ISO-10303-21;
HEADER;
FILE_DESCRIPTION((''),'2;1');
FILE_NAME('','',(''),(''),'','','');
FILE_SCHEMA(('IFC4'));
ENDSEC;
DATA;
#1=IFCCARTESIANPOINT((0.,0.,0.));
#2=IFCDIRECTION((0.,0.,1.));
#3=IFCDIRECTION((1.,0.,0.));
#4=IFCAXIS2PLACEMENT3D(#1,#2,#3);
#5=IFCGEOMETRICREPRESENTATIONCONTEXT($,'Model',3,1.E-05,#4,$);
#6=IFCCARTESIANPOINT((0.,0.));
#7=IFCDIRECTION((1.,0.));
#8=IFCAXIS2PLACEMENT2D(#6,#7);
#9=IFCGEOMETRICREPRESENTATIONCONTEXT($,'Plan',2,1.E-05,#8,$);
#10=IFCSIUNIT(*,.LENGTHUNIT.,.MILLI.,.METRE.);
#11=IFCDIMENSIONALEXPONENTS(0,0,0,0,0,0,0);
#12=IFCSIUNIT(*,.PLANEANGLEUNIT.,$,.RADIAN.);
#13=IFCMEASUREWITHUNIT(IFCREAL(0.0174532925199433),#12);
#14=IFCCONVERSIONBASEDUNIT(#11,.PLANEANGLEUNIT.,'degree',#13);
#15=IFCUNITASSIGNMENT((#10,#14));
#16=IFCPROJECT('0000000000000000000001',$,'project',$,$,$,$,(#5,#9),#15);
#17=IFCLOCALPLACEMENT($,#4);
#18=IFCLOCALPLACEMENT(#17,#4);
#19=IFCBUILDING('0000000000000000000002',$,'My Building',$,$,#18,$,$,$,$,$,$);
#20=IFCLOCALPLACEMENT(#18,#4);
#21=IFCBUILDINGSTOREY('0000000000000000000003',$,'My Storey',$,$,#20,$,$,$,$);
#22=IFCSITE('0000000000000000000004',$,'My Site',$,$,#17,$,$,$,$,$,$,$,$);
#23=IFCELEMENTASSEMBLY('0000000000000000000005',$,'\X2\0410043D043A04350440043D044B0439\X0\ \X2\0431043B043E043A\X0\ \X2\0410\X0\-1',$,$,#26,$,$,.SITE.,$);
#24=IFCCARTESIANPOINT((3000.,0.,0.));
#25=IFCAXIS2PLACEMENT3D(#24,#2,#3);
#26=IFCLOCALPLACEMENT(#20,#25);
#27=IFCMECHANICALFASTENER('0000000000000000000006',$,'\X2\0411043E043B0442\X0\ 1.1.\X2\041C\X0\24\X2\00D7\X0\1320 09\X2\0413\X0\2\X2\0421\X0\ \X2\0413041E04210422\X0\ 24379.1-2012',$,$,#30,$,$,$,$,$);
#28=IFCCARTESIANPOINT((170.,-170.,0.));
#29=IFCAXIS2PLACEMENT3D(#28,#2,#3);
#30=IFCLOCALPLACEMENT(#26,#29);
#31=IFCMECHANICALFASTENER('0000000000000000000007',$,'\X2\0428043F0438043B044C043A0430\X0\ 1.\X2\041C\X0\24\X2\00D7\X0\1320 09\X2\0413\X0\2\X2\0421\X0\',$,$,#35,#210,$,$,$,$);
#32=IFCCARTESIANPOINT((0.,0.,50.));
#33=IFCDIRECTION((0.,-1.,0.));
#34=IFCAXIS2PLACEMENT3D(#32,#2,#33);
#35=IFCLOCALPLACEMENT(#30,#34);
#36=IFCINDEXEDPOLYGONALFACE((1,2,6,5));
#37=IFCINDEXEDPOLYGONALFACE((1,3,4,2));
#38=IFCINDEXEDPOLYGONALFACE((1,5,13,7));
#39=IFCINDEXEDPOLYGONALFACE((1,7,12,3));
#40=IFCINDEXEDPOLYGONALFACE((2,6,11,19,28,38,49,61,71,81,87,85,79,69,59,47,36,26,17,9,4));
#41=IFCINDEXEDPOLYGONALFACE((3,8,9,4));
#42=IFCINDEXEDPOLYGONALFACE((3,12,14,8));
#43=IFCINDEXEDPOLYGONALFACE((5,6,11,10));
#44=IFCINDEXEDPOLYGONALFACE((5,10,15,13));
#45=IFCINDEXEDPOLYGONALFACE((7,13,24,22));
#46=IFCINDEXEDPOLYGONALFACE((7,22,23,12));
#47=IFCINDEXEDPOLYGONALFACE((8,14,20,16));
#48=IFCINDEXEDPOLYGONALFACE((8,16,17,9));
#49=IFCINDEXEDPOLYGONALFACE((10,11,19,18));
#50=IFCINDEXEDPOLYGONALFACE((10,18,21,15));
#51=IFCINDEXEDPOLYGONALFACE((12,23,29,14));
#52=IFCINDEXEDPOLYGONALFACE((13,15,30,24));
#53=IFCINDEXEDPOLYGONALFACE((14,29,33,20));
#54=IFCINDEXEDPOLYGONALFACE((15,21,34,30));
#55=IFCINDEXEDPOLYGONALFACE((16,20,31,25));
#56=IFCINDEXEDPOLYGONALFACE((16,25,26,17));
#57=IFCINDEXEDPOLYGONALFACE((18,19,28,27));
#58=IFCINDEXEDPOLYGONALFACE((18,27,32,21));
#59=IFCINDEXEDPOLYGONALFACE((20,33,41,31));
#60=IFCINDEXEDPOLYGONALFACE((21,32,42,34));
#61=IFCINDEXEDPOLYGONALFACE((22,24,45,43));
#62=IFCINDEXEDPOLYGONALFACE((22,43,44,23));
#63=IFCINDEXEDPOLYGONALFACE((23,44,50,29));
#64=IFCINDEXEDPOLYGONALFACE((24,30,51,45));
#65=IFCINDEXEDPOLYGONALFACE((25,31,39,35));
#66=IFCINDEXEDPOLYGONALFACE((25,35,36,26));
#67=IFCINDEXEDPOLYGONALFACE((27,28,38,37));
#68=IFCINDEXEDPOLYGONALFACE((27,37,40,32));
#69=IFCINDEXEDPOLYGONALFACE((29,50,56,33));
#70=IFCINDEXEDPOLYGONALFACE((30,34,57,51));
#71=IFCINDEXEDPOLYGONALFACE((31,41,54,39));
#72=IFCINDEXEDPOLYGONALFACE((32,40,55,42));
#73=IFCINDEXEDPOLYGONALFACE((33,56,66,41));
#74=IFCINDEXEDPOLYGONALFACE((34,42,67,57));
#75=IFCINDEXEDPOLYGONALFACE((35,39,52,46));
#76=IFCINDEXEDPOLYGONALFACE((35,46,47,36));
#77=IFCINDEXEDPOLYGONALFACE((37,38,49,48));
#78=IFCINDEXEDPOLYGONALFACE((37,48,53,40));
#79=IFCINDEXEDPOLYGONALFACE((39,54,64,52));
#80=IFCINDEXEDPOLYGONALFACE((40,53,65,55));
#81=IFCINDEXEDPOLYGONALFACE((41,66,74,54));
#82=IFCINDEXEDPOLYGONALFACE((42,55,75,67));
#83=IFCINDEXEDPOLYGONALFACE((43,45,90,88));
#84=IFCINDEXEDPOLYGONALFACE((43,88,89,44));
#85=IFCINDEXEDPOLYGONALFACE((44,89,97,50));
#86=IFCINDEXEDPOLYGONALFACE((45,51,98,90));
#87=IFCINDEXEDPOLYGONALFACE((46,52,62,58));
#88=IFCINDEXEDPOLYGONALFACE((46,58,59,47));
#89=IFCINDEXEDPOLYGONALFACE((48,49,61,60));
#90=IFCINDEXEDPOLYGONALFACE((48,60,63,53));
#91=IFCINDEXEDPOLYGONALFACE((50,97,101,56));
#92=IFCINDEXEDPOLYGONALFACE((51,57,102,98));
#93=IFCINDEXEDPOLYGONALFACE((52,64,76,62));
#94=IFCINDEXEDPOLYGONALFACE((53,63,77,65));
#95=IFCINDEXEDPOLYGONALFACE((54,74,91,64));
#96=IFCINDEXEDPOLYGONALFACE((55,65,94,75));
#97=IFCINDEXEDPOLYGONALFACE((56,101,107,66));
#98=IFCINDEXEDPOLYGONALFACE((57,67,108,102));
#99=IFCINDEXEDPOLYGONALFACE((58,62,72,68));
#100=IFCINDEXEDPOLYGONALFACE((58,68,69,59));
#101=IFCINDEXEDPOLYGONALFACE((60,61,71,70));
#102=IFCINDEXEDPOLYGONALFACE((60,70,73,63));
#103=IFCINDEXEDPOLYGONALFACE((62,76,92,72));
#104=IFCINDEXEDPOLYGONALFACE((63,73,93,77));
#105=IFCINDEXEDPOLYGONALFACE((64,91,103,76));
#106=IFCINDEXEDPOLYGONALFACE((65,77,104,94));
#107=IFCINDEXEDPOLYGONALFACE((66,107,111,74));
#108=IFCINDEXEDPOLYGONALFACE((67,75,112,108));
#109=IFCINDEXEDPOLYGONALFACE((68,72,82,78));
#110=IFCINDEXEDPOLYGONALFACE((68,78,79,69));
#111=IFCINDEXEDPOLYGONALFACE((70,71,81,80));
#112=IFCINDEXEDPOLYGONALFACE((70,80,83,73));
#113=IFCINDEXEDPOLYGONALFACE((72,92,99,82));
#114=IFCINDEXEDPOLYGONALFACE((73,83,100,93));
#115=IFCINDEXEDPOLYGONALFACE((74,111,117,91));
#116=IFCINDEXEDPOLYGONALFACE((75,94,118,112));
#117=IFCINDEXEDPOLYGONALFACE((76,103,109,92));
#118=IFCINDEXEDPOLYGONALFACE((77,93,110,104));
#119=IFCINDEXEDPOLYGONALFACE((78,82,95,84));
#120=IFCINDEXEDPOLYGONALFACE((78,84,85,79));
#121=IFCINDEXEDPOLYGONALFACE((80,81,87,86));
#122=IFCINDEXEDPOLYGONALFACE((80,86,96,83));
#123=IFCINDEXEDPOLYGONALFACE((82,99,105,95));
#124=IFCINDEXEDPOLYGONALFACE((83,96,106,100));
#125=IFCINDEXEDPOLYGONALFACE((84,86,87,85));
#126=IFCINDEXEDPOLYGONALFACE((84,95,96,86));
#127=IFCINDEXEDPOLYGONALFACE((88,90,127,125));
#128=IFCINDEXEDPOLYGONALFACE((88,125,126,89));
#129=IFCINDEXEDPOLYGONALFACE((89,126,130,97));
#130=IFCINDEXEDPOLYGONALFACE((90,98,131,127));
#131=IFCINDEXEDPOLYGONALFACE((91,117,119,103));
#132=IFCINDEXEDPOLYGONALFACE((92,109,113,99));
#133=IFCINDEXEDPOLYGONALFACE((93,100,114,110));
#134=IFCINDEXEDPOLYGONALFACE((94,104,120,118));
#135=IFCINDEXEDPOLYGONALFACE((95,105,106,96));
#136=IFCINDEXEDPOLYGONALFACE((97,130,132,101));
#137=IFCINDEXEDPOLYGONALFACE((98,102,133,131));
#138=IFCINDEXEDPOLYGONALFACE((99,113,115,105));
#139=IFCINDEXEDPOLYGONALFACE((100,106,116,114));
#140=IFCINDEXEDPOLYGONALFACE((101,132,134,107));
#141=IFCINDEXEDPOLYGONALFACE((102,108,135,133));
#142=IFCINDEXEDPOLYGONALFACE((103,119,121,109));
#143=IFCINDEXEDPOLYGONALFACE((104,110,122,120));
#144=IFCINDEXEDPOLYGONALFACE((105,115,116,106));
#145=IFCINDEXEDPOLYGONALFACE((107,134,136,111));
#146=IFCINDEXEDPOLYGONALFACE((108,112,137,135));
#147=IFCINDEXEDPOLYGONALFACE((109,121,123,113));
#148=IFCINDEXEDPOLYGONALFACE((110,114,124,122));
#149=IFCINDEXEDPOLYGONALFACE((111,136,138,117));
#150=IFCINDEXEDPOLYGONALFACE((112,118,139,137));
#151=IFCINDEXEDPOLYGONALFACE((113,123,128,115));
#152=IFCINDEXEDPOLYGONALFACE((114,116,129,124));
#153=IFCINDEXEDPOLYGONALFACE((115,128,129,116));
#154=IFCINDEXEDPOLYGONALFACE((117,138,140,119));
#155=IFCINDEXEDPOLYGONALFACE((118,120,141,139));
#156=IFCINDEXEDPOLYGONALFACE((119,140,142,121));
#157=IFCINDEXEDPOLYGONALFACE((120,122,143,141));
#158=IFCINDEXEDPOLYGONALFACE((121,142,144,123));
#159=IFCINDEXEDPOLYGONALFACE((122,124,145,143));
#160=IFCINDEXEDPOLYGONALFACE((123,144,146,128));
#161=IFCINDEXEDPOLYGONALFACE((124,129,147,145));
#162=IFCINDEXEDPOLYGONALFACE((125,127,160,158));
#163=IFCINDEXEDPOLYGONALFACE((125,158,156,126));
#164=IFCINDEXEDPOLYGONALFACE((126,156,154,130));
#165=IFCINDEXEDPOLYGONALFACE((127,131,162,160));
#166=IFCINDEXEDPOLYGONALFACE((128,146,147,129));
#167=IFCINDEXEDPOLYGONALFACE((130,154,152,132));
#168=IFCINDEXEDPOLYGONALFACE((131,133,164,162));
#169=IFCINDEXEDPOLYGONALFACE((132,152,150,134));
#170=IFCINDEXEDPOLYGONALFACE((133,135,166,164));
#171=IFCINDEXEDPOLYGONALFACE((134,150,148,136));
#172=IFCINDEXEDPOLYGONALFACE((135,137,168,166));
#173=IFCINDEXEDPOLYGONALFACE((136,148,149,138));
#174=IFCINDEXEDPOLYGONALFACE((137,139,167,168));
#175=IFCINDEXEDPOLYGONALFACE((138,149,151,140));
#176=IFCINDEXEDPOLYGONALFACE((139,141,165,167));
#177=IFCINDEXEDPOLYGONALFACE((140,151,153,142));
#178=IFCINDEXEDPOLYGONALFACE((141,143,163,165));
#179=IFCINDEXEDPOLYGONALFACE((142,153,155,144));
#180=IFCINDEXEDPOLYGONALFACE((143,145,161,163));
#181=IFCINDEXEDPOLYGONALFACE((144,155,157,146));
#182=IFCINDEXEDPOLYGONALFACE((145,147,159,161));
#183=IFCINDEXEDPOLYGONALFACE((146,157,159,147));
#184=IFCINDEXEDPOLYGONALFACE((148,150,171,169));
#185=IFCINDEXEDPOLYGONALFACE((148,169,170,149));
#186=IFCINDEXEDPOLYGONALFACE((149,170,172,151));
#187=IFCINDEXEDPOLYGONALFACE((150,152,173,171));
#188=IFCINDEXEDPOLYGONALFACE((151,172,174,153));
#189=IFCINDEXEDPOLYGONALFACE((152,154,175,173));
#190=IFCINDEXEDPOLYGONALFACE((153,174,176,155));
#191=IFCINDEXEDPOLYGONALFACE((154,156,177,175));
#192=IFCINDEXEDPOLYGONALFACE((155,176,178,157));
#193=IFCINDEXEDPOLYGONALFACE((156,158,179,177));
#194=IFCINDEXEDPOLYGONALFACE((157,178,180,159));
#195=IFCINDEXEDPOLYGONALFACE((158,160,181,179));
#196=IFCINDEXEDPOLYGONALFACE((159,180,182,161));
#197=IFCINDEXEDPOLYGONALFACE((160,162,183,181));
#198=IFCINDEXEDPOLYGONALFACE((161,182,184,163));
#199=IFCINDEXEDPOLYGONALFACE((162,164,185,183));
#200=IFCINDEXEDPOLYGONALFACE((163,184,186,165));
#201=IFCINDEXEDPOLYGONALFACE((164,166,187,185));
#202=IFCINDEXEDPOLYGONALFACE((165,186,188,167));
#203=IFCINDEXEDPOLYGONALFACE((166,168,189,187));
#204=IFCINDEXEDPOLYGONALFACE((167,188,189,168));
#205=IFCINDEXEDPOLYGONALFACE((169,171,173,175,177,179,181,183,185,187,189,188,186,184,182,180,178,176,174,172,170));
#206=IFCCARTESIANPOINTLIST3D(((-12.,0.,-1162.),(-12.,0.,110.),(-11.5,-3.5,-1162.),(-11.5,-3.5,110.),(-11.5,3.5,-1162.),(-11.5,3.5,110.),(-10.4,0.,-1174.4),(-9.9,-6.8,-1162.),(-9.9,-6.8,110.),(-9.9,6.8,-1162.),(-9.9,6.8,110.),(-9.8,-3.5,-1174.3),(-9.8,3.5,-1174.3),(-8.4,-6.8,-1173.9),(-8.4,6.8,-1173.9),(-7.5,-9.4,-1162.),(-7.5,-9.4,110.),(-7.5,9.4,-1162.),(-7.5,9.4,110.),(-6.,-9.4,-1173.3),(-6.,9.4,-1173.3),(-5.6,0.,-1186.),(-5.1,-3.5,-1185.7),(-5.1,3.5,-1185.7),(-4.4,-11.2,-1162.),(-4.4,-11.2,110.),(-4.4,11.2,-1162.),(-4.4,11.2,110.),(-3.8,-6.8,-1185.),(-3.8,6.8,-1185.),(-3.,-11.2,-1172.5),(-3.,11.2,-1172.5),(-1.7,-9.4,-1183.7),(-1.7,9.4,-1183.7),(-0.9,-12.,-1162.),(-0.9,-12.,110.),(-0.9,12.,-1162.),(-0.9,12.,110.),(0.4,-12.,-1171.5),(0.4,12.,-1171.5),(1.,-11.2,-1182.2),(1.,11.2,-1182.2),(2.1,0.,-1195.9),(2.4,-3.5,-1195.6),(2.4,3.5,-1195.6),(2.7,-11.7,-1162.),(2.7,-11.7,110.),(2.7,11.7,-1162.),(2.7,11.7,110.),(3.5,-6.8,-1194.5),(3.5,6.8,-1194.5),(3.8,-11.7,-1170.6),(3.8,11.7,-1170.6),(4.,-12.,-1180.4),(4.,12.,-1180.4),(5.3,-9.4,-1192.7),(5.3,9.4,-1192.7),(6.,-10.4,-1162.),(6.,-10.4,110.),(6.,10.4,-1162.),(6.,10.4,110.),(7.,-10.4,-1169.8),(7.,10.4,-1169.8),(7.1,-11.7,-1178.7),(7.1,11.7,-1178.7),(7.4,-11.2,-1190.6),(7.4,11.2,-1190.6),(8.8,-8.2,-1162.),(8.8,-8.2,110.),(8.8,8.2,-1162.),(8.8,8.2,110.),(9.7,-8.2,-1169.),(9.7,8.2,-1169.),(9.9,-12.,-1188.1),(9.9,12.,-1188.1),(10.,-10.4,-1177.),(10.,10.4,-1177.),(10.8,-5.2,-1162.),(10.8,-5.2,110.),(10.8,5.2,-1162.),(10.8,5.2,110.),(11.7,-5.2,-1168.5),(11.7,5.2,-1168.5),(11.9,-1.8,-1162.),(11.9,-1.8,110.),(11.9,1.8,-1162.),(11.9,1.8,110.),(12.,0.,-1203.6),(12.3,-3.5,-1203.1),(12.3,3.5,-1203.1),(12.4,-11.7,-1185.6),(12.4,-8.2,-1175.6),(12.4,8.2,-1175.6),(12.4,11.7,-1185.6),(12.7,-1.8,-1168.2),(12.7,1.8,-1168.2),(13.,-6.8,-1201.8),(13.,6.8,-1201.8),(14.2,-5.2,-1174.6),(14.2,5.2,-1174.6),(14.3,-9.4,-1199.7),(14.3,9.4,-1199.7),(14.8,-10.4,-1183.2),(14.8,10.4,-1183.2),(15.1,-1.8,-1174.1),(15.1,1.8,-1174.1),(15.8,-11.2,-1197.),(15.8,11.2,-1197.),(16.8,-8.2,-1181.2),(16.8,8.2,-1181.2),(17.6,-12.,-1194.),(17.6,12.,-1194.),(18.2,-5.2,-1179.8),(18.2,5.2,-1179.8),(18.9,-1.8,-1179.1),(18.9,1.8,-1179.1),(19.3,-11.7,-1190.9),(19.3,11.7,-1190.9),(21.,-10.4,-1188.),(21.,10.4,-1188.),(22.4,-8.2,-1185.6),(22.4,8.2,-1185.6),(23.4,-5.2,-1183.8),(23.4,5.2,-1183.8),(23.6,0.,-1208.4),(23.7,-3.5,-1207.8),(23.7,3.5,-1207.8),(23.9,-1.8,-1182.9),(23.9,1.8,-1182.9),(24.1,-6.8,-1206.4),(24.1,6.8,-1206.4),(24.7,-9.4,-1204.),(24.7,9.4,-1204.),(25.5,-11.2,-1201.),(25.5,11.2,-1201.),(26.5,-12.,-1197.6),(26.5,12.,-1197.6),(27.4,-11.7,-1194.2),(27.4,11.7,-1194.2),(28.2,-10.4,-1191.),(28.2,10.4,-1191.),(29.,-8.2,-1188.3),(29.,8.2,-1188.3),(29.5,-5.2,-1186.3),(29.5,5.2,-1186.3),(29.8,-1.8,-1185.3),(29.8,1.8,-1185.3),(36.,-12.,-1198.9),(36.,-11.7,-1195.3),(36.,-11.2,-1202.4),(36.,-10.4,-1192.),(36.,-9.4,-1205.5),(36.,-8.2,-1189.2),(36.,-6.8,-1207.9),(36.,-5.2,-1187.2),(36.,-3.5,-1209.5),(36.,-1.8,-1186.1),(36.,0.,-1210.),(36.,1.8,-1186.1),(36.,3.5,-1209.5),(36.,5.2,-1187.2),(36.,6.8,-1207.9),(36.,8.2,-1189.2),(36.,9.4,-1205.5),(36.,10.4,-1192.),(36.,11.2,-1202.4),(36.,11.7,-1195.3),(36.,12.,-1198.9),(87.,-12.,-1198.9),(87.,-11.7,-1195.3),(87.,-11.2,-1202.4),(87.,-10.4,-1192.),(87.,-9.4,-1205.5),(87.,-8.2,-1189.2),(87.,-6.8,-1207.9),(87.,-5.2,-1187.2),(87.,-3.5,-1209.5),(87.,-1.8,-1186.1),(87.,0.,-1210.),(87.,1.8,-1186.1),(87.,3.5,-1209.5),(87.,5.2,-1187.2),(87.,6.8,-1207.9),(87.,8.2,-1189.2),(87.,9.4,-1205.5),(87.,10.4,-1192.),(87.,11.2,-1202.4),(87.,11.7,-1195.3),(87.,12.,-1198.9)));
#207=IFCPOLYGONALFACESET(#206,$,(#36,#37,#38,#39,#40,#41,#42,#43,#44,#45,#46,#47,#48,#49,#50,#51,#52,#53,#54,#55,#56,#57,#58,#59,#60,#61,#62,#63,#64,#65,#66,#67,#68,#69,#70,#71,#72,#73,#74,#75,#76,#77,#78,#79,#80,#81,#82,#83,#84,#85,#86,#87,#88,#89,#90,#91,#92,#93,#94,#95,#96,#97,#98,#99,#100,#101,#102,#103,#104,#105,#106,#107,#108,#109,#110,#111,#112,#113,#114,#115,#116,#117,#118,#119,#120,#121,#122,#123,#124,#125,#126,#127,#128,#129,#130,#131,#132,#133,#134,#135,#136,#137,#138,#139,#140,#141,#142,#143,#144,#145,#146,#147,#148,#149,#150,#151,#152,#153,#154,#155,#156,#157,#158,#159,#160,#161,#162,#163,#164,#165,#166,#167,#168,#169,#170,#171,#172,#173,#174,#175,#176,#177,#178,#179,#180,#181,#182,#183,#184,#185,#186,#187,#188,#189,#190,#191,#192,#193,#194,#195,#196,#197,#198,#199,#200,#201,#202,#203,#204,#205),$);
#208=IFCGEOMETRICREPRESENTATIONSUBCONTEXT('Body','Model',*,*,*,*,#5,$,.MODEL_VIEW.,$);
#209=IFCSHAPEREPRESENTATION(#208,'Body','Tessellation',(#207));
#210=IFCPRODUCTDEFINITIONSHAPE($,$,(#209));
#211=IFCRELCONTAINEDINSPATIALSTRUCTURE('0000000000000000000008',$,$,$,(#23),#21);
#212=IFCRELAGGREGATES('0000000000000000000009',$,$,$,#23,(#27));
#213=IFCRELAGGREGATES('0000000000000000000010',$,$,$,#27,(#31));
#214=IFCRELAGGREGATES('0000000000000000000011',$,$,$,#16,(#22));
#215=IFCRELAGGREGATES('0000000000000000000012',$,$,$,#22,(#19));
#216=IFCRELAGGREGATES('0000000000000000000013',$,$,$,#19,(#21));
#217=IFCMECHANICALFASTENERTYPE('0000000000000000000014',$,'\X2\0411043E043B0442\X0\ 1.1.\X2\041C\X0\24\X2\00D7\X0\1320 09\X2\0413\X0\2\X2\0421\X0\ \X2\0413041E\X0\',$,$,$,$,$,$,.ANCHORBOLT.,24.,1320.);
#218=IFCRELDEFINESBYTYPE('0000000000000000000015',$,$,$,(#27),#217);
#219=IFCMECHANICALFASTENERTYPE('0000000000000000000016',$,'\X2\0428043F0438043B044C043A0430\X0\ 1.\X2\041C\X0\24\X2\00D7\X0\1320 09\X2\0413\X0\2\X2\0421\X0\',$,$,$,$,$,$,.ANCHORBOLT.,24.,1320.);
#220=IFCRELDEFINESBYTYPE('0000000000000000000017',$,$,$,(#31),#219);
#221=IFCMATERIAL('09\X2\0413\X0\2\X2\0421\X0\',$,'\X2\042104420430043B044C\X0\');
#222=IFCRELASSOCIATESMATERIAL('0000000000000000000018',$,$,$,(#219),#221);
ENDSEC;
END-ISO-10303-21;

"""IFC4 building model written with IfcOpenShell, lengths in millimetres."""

from ifc_helpers import new_model, entity, si_unit, converted_unit, frame, origin_with_axes, origin_2d_with_axis, place, context, subcontext, project, spatial, source, transform, mapped, material, type_object, type_shapes, element, aggregate, save


model = new_model("IFC4")

# Units and contexts
model_context = context("Model", 3, precision=1e-05, world=origin_with_axes())
plan_context = context("Plan", 2, precision=1e-05, world=origin_2d_with_axis())
body_context = subcontext(model_context, "Body", "Model", "MODEL_VIEW")
ifc_project = project(units=[si_unit("LENGTHUNIT", "METRE", prefix="MILLI"), converted_unit("PLANEANGLEUNIT", "degree", entity("IfcReal", 0.0174532925199433), si_unit("PLANEANGLEUNIT", "RADIAN"), dimensions=[0, 0, 0, 0, 0, 0, 0])], contexts=[model_context, plan_context])

# Site, building, storey
site_placement = place(None, origin_with_axes())
site = spatial("IfcSite", under=ifc_project, at=site_placement, Name="My Site")
building_placement = place(site_placement, origin_with_axes())
building = spatial("IfcBuilding", under=site, at=building_placement, Name="My Building")
storey_placement = place(building_placement, origin_with_axes())
storey = spatial("IfcBuildingStorey", under=building, at=storey_placement, Name="My Storey")

# Shared definitions
placement = place(storey_placement, frame((3000.0, 0.0, 0.0), z_axis=(0.0, 0.0, 1.0), x_axis=(1.0, 0.0, 0.0)))

# Element assembly, mechanical fasteners
assembly = element("IfcElementAssembly", 1, at=placement, inside=storey, Name="Анкерный блок А-1", AssemblyPlace="SITE")
mechanical_fastener_type_1 = type_object("IfcMechanicalFastenerType", Name="Болт 1.1.М24×1320 09Г2С ГО", NominalDiameter=24.0, NominalLength=1320.0, PredefinedType="ANCHORBOLT")
ifc_material_1 = material(Name="09Г2С", Category="Сталь")
mechanical_fastener_type_2 = type_object("IfcMechanicalFastenerType", Name="Шпилька 1.М24×1320 09Г2С", NominalDiameter=24.0, NominalLength=1320.0, PredefinedType="ANCHORBOLT", material=ifc_material_1)
shared_shape_1 = source(frame((0.0, 0.0, 110.0), z_axis=(0.0, 0.0, 1.0), x_axis=(1.0, 0.0, 0.0)), body_context, "Body", "AdvancedSweptSolid", [
    entity("IfcSweptDiskSolid", entity("IfcIndexedPolyCurve", entity("IfcCartesianPointList3D", [[0.0, 0.0, 0.0], [0.0, 0.0, -1272.0], [10.5, 0.0, -1297.5], [36.0, 0.0, -1308.0], [87.0, 0.0, -1308.0]]), [entity("IfcLineIndex", [1, 2]), entity("IfcArcIndex", [2, 3, 4]), entity("IfcLineIndex", [4, 5])]), 12.0),
])
type_shapes(mechanical_fastener_type_2, [shared_shape_1])
mechanical_fastener_1_placement = place(placement, frame((170.0, -170.0, 0.0), z_axis=(0.0, 0.0, 1.0), x_axis=(1.0, 0.0, 0.0)))
mechanical_fastener_1 = element("IfcMechanicalFastener", 2, at=mechanical_fastener_1_placement, type_object=mechanical_fastener_type_1, Name="Болт 1.1.М24×1320 09Г2С ГОСТ 24379.1-2012")
mechanical_fastener_2_placement = place(mechanical_fastener_1_placement, frame((0.0, 0.0, 50.0), z_axis=(0.0, 0.0, 1.0), x_axis=(0.0, -1.0, 0.0)))
mechanical_fastener_2 = element("IfcMechanicalFastener", 3, at=mechanical_fastener_2_placement, type_object=mechanical_fastener_type_2, Name="Шпилька 1.М24×1320 09Г2С", context=body_context, shape_type="MappedRepresentation", body=[
    mapped(shared_shape_1, transform((0.0, 0.0, 0.0), x_axis=(1.0, 0.0, 0.0), y_axis=(0.0, 1.0, 0.0), z_axis=(0.0, 0.0, 1.0), scale=1.0)),
])
aggregate(assembly, [mechanical_fastener_1])
aggregate(mechanical_fastener_1, [mechanical_fastener_2])

save(model, "model.ifc")
